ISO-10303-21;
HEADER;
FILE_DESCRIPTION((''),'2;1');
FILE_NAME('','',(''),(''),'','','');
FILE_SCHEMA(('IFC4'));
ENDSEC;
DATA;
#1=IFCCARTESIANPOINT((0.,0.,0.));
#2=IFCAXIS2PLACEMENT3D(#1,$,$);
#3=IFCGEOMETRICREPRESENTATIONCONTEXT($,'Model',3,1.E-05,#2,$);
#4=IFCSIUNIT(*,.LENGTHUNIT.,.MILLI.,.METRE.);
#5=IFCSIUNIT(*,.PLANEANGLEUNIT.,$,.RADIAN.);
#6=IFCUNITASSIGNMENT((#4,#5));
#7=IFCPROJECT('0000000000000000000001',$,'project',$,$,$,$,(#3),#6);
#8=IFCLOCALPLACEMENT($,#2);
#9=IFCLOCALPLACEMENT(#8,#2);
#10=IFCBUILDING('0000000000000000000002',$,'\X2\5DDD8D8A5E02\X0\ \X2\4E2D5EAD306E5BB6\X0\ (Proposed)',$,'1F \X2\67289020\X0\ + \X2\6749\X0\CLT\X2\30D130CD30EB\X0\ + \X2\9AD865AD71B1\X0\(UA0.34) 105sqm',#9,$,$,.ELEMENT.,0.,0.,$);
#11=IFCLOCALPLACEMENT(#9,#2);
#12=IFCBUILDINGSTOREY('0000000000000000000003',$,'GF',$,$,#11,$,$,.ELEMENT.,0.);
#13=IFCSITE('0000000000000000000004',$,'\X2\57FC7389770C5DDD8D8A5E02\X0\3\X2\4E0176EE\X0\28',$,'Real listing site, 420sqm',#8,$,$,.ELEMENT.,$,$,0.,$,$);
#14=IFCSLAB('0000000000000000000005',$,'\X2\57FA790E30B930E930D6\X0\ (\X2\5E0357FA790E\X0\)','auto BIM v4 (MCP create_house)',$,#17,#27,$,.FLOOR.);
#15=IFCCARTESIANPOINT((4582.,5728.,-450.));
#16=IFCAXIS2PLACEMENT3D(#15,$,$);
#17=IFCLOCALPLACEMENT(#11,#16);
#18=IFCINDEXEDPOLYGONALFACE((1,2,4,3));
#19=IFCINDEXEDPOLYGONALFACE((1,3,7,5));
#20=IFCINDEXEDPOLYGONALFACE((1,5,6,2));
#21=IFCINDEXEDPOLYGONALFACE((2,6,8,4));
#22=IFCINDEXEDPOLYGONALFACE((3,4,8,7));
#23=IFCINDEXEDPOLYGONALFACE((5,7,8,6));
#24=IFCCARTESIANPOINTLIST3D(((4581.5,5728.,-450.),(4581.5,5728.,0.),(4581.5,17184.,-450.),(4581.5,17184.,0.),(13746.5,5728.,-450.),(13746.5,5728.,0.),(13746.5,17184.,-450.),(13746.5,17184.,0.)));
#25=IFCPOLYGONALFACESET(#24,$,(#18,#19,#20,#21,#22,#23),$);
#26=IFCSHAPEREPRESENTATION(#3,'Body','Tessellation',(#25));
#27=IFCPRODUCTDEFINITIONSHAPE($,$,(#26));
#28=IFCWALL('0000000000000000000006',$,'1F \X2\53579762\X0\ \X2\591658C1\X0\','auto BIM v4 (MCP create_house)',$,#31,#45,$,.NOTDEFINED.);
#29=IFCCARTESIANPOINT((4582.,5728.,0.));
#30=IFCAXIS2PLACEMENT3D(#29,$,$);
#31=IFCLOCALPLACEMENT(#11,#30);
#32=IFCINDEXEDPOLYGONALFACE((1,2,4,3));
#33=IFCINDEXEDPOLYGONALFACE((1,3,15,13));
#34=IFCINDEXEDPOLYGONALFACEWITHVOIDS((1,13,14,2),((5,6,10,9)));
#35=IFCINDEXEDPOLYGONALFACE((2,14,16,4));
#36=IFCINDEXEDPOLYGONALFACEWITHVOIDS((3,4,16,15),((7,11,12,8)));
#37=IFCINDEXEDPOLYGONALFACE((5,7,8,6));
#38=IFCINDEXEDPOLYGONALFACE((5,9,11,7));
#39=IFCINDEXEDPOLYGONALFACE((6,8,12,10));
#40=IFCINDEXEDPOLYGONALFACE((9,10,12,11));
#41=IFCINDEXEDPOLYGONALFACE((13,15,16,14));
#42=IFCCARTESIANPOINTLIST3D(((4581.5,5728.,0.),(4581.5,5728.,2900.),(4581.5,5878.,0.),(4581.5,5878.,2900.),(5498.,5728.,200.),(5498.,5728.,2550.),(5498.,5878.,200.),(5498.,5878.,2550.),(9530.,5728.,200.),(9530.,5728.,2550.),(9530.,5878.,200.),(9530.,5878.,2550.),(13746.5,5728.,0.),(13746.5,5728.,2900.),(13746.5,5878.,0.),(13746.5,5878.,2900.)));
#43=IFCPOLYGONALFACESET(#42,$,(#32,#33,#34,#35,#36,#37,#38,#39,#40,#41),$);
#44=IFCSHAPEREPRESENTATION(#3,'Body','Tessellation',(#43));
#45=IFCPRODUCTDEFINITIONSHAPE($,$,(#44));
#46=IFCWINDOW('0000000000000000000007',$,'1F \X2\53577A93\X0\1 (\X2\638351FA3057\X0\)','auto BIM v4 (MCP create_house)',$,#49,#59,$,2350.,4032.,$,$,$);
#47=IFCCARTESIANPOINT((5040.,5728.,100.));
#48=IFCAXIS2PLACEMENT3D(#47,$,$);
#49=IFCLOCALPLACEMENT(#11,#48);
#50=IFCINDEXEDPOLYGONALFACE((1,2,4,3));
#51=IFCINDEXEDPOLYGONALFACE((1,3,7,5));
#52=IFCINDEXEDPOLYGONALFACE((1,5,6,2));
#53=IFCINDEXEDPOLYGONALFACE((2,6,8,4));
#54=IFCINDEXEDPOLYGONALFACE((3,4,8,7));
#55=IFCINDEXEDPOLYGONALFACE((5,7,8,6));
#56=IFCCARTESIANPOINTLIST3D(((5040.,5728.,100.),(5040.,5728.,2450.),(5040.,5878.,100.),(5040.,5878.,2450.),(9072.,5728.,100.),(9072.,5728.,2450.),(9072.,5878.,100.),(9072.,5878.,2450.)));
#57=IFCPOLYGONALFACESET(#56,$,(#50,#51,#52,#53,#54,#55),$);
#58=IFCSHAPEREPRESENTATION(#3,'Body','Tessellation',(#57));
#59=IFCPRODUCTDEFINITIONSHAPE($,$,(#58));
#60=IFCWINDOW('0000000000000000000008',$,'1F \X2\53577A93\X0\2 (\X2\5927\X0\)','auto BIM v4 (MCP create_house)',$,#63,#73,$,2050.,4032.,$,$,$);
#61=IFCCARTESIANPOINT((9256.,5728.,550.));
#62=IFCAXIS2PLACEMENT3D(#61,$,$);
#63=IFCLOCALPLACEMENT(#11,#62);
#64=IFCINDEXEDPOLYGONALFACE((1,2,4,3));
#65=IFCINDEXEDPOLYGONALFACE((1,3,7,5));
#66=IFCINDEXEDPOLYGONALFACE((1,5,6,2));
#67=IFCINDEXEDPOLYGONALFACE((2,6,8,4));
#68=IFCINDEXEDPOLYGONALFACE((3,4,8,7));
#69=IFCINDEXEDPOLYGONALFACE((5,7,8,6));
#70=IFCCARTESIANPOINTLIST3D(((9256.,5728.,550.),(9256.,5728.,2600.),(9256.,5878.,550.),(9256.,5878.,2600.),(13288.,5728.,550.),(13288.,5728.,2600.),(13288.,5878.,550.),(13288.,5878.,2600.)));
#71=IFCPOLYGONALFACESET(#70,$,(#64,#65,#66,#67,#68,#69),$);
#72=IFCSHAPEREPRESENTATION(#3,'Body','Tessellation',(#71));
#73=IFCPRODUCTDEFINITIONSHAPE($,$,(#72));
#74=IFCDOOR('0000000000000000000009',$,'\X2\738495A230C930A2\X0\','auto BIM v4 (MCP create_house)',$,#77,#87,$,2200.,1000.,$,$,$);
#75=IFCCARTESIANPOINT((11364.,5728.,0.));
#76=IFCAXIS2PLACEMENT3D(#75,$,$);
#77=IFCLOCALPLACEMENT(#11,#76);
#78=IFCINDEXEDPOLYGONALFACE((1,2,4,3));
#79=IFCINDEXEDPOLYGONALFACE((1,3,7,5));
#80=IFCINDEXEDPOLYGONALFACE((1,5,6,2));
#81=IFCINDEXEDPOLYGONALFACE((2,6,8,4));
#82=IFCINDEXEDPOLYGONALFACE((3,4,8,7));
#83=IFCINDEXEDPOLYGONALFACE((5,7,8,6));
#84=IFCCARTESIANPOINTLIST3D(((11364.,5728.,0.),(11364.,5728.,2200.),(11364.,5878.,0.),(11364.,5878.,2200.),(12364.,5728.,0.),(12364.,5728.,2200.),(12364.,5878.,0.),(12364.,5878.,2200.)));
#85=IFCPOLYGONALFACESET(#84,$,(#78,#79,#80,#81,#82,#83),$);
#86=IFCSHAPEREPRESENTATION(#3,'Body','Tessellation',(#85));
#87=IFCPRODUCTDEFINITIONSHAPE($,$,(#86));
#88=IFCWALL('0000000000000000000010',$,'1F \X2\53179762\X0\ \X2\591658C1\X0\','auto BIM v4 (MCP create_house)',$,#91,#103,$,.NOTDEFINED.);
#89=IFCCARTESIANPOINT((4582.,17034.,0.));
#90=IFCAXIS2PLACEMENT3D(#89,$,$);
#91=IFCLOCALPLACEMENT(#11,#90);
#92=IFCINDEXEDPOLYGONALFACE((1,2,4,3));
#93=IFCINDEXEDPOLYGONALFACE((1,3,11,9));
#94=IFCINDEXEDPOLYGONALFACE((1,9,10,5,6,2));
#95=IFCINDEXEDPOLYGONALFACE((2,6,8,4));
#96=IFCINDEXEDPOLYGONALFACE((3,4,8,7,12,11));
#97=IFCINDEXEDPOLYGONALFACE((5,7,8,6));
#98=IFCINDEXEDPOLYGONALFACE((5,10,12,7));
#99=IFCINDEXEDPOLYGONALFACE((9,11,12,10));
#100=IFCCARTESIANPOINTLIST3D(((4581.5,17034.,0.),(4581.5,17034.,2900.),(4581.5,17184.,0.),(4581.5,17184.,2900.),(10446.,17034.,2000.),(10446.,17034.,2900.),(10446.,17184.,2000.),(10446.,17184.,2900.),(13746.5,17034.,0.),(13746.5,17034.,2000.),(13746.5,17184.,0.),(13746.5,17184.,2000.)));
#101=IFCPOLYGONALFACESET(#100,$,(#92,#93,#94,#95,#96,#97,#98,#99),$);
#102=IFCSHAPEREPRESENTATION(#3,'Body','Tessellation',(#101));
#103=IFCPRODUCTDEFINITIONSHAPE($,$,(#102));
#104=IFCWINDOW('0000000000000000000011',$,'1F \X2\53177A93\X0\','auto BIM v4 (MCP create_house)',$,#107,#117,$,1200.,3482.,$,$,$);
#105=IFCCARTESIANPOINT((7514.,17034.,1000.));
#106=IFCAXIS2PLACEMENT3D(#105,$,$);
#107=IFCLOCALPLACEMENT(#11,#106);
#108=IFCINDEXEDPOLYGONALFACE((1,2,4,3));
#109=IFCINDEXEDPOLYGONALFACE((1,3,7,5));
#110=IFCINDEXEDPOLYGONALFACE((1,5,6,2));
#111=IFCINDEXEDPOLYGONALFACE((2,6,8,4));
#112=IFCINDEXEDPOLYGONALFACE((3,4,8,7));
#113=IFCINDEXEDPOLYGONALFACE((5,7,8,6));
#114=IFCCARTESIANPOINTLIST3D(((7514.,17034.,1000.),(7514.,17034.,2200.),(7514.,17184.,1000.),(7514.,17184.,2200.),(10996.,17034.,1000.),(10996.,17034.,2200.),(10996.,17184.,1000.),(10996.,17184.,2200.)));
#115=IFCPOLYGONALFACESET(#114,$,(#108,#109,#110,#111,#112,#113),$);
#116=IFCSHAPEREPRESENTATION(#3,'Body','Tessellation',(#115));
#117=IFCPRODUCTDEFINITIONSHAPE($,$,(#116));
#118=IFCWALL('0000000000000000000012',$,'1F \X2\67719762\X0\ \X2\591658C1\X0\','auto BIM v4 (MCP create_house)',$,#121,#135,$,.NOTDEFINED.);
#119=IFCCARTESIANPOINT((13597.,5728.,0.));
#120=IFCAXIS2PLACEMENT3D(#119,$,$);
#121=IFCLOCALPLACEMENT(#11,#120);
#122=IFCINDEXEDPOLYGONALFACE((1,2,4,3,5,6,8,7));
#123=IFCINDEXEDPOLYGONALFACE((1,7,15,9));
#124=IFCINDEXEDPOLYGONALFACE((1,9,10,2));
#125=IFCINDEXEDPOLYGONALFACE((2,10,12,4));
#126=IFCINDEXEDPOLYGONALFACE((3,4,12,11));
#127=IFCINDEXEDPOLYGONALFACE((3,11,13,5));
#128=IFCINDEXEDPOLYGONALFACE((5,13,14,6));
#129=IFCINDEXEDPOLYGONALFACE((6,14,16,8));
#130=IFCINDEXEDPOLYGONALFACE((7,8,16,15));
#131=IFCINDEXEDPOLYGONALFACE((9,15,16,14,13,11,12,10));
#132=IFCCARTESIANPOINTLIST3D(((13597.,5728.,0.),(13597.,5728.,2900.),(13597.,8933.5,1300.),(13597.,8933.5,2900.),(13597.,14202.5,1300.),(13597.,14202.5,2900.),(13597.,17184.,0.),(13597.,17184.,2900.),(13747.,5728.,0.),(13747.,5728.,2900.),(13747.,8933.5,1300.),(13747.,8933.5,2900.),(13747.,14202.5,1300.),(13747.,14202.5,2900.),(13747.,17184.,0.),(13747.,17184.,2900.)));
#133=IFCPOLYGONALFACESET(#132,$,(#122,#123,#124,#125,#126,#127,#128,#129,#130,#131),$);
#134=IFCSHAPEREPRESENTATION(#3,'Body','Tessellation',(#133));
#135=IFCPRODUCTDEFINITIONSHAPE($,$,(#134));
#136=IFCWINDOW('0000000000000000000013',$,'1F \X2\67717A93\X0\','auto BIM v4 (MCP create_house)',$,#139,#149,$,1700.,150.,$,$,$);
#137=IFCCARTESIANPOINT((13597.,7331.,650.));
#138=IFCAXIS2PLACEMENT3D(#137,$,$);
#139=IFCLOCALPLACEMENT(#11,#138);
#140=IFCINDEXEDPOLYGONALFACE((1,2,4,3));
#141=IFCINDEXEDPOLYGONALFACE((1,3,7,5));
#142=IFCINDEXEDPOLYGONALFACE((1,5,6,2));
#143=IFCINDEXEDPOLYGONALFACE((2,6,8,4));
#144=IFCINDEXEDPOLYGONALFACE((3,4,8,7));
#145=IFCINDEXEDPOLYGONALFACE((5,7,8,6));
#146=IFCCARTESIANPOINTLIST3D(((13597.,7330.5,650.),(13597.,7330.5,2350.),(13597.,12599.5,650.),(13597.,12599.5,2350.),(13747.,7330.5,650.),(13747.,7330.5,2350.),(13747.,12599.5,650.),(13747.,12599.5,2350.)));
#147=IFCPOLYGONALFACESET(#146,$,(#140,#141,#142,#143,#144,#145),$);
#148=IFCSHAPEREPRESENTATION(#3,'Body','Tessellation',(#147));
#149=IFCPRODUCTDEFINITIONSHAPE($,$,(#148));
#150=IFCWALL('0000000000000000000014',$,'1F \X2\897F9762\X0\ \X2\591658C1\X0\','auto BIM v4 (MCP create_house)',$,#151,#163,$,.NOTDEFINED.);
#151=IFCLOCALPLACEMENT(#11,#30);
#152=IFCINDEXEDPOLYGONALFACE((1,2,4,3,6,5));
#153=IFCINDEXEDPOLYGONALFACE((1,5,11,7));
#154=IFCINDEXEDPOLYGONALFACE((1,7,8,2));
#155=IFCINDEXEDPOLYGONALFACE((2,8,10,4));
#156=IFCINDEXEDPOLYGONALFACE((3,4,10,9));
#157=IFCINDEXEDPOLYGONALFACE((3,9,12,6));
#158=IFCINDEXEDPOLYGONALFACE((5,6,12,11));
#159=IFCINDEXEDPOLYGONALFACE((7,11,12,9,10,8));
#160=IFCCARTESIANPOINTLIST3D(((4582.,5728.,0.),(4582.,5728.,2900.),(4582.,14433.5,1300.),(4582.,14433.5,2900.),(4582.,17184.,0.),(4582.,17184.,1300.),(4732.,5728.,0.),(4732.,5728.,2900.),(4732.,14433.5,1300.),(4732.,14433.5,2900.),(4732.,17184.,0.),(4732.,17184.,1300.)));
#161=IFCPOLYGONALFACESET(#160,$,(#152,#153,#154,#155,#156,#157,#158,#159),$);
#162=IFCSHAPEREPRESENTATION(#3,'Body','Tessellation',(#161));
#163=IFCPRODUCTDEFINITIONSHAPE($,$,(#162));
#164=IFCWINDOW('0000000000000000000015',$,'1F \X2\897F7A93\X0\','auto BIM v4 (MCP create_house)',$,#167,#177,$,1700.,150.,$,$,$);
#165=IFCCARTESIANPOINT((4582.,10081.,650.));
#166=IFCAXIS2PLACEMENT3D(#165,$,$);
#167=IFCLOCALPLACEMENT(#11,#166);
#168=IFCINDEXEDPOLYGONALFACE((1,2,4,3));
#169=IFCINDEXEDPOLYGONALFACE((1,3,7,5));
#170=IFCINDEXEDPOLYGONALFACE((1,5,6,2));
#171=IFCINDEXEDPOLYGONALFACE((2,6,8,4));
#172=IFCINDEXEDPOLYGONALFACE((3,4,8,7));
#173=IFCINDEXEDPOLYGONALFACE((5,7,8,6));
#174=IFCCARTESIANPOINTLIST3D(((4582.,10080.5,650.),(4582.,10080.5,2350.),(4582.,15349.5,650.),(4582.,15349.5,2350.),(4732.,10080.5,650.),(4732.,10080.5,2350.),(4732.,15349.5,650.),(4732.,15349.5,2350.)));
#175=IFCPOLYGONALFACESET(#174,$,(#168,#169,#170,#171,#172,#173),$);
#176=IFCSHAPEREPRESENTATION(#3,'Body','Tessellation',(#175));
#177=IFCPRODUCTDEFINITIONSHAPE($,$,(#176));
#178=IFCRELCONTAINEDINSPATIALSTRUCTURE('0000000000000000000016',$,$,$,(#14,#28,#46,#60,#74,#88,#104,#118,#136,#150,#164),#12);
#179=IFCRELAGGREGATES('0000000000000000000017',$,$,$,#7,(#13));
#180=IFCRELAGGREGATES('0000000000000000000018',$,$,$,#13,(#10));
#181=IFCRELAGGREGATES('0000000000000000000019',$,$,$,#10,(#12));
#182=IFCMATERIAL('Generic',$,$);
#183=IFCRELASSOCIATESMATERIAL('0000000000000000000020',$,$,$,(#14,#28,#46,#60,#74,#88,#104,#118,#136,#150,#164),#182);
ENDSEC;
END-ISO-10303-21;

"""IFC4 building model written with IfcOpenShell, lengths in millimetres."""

from ifc_helpers import new_model, si_unit, frame, frame_2d, origin, place, context, project, spatial, rectangle, extrude, material, element, fill, save


model = new_model("IFC4")

# Units and contexts
model_context = context("Model", 3, precision=1e-05, world=origin())
ifc_project = project(units=[si_unit("LENGTHUNIT", "METRE", prefix="MILLI"), si_unit("PLANEANGLEUNIT", "RADIAN")], contexts=[model_context])

# Site, building, storey
site_placement = place(None, origin())
site = spatial("IfcSite", under=ifc_project, at=site_placement, Name="埼玉県川越市3丁目28", ObjectType="Real listing site, 420sqm", CompositionType="ELEMENT", RefElevation=0.0)
building_placement = place(site_placement, origin())
building = spatial("IfcBuilding", under=site, at=building_placement, Name="川越市 中庭の家 (Proposed)", ObjectType="1F 木造 + 杉CLTパネル + 高断熱(UA0.34) 105sqm", CompositionType="ELEMENT", ElevationOfRefHeight=0.0, ElevationOfTerrain=0.0)
storey_placement = place(building_placement, origin())
storey = spatial("IfcBuildingStorey", under=building, at=storey_placement, Name="GF", CompositionType="ELEMENT", Elevation=0.0)

# Slab
ifc_material = material(Name="Generic")
slab_1_placement = place(storey_placement, frame((4582.0, 5728.0, -450.0)))
element("IfcSlab", 1, at=slab_1_placement, inside=storey, material=ifc_material, Name="基礎スラブ (布基礎)", Description="auto BIM v4 (MCP create_house)", PredefinedType="FLOOR", context=model_context, shape_type="SweptSolid", body=[
    extrude(rectangle(XDim=9165.0, YDim=11456.0, at=frame_2d((4582.0, 5728.0))), frame((4582.0, 5728.0, -450.0)), (0.0, 0.0, 1.0), 450.0),
])

# Wall, openings, windows, door
wall_1_placement = place(storey_placement, frame((4582.0, 5728.0, 0.0)))
wall_1 = element("IfcWall", 2, at=wall_1_placement, inside=storey, material=ifc_material, Name="1F 南面 外壁", Description="auto BIM v4 (MCP create_house)", PredefinedType="NOTDEFINED", context=model_context, shape_type="SweptSolid", body=[
    extrude(rectangle(XDim=9165.0, YDim=150.0, at=frame_2d((4582.0, 75.0))), frame((4582.0, 5728.0, 0.0)), (0.0, 0.0, 1.0), 2900.0),
])
opening_1_placement = place(storey_placement, frame((5040.0, 5728.0, 100.0)))
opening_1 = element("IfcOpeningElement", 3, at=opening_1_placement, cuts=wall_1, PredefinedType="NOTDEFINED", context=model_context, shape_type="SweptSolid", body=[
    extrude(rectangle(XDim=4032.0, YDim=150.0, at=frame_2d((2016.0, 75.0))), frame((5040.0, 5728.0, 100.0)), (0.0, 0.0, 1.0), 2350.0),
])
opening_2_placement = place(storey_placement, frame((9256.0, 5728.0, 550.0)))
opening_2 = element("IfcOpeningElement", 4, at=opening_2_placement, cuts=wall_1, PredefinedType="NOTDEFINED", context=model_context, shape_type="SweptSolid", body=[
    extrude(rectangle(XDim=4032.0, YDim=150.0, at=frame_2d((2016.0, 75.0))), frame((9256.0, 5728.0, 550.0)), (0.0, 0.0, 1.0), 2050.0),
])
opening_3_placement = place(storey_placement, frame((11364.0, 5728.0, 0.0)))
opening_3 = element("IfcOpeningElement", 5, at=opening_3_placement, cuts=wall_1, PredefinedType="NOTDEFINED", context=model_context, shape_type="SweptSolid", body=[
    extrude(rectangle(XDim=1000.0, YDim=150.0, at=frame_2d((500.0, 75.0))), frame((11364.0, 5728.0, 0.0)), (0.0, 0.0, 1.0), 2200.0),
])
window_1_placement = place(storey_placement, frame((5040.0, 5728.0, 100.0)))
window_1 = element("IfcWindow", 6, at=window_1_placement, inside=storey, material=ifc_material, Name="1F 南窓1 (掃出し)", Description="auto BIM v4 (MCP create_house)", OverallHeight=2350.0, OverallWidth=4032.0, context=model_context, shape_type="SweptSolid", body=[
    extrude(rectangle(XDim=4032.0, YDim=150.0, at=frame_2d((2016.0, 75.0))), frame((5040.0, 5728.0, 100.0)), (0.0, 0.0, 1.0), 2350.0),
])
fill(opening_1, window_1)
window_2_placement = place(storey_placement, frame((9256.0, 5728.0, 550.0)))
window_2 = element("IfcWindow", 7, at=window_2_placement, inside=storey, material=ifc_material, Name="1F 南窓2 (大)", Description="auto BIM v4 (MCP create_house)", OverallHeight=2050.0, OverallWidth=4032.0, context=model_context, shape_type="SweptSolid", body=[
    extrude(rectangle(XDim=4032.0, YDim=150.0, at=frame_2d((2016.0, 75.0))), frame((9256.0, 5728.0, 550.0)), (0.0, 0.0, 1.0), 2050.0),
])
fill(opening_2, window_2)
door_placement = place(storey_placement, frame((11364.0, 5728.0, 0.0)))
door = element("IfcDoor", 8, at=door_placement, inside=storey, material=ifc_material, Name="玄関ドア", Description="auto BIM v4 (MCP create_house)", OverallHeight=2200.0, OverallWidth=1000.0, context=model_context, shape_type="SweptSolid", body=[
    extrude(rectangle(XDim=1000.0, YDim=150.0, at=frame_2d((500.0, 75.0))), frame((11364.0, 5728.0, 0.0)), (0.0, 0.0, 1.0), 2200.0),
])
fill(opening_3, door)

# Walls, openings, windows
wall_2_placement = place(storey_placement, frame((4582.0, 17034.0, 0.0)))
wall_2 = element("IfcWall", 9, at=wall_2_placement, inside=storey, material=ifc_material, Name="1F 北面 外壁", Description="auto BIM v4 (MCP create_house)", PredefinedType="NOTDEFINED", context=model_context, shape_type="SweptSolid", body=[
    extrude(rectangle(XDim=9165.0, YDim=150.0, at=frame_2d((4582.0, 75.0))), frame((4582.0, 17034.0, 0.0)), (0.0, 0.0, 1.0), 2900.0),
])
opening_4_placement = place(storey_placement, frame((7514.0, 17034.0, 1000.0)))
opening_4 = element("IfcOpeningElement", 10, at=opening_4_placement, cuts=wall_2, PredefinedType="NOTDEFINED", context=model_context, shape_type="SweptSolid", body=[
    extrude(rectangle(XDim=3482.0, YDim=150.0, at=frame_2d((1741.0, 75.0))), frame((7514.0, 17034.0, 1000.0)), (0.0, 0.0, 1.0), 1200.0),
])
window_3_placement = place(storey_placement, frame((7514.0, 17034.0, 1000.0)))
window_3 = element("IfcWindow", 11, at=window_3_placement, inside=storey, material=ifc_material, Name="1F 北窓", Description="auto BIM v4 (MCP create_house)", OverallHeight=1200.0, OverallWidth=3482.0, context=model_context, shape_type="SweptSolid", body=[
    extrude(rectangle(XDim=3482.0, YDim=150.0, at=frame_2d((1741.0, 75.0))), frame((7514.0, 17034.0, 1000.0)), (0.0, 0.0, 1.0), 1200.0),
])
fill(opening_4, window_3)
wall_3_placement = place(storey_placement, frame((13597.0, 5728.0, 0.0)))
wall_3 = element("IfcWall", 12, at=wall_3_placement, inside=storey, material=ifc_material, Name="1F 東面 外壁", Description="auto BIM v4 (MCP create_house)", PredefinedType="NOTDEFINED", context=model_context, shape_type="SweptSolid", body=[
    extrude(rectangle(XDim=150.0, YDim=11456.0, at=frame_2d((75.0, 5728.0))), frame((13597.0, 5728.0, 0.0)), (0.0, 0.0, 1.0), 2900.0),
])
opening_5_placement = place(storey_placement, frame((13597.0, 7331.0, 650.0)))
opening_5 = element("IfcOpeningElement", 13, at=opening_5_placement, cuts=wall_3, PredefinedType="NOTDEFINED", context=model_context, shape_type="SweptSolid", body=[
    extrude(rectangle(XDim=150.0, YDim=5269.0, at=frame_2d((75.0, 2634.0))), frame((13597.0, 7331.0, 650.0)), (0.0, 0.0, 1.0), 1700.0),
])
window_4_placement = place(storey_placement, frame((13597.0, 7331.0, 650.0)))
window_4 = element("IfcWindow", 14, at=window_4_placement, inside=storey, material=ifc_material, Name="1F 東窓", Description="auto BIM v4 (MCP create_house)", OverallHeight=1700.0, OverallWidth=150.0, context=model_context, shape_type="SweptSolid", body=[
    extrude(rectangle(XDim=150.0, YDim=5269.0, at=frame_2d((75.0, 2634.0))), frame((13597.0, 7331.0, 650.0)), (0.0, 0.0, 1.0), 1700.0),
])
fill(opening_5, window_4)
wall_4_placement = place(storey_placement, frame((4582.0, 5728.0, 0.0)))
wall_4 = element("IfcWall", 15, at=wall_4_placement, inside=storey, material=ifc_material, Name="1F 西面 外壁", Description="auto BIM v4 (MCP create_house)", PredefinedType="NOTDEFINED", context=model_context, shape_type="SweptSolid", body=[
    extrude(rectangle(XDim=150.0, YDim=11456.0, at=frame_2d((75.0, 5728.0))), frame((4582.0, 5728.0, 0.0)), (0.0, 0.0, 1.0), 2900.0),
])
opening_6_placement = place(storey_placement, frame((4582.0, 10081.0, 650.0)))
opening_6 = element("IfcOpeningElement", 16, at=opening_6_placement, cuts=wall_4, PredefinedType="NOTDEFINED", context=model_context, shape_type="SweptSolid", body=[
    extrude(rectangle(XDim=150.0, YDim=5269.0, at=frame_2d((75.0, 2634.0))), frame((4582.0, 10081.0, 650.0)), (0.0, 0.0, 1.0), 1700.0),
])
window_5_placement = place(storey_placement, frame((4582.0, 10081.0, 650.0)))
window_5 = element("IfcWindow", 17, at=window_5_placement, inside=storey, material=ifc_material, Name="1F 西窓", Description="auto BIM v4 (MCP create_house)", OverallHeight=1700.0, OverallWidth=150.0, context=model_context, shape_type="SweptSolid", body=[
    extrude(rectangle(XDim=150.0, YDim=5269.0, at=frame_2d((75.0, 2634.0))), frame((4582.0, 10081.0, 650.0)), (0.0, 0.0, 1.0), 1700.0),
])
fill(opening_6, window_5)

save(model, "model.ifc")
